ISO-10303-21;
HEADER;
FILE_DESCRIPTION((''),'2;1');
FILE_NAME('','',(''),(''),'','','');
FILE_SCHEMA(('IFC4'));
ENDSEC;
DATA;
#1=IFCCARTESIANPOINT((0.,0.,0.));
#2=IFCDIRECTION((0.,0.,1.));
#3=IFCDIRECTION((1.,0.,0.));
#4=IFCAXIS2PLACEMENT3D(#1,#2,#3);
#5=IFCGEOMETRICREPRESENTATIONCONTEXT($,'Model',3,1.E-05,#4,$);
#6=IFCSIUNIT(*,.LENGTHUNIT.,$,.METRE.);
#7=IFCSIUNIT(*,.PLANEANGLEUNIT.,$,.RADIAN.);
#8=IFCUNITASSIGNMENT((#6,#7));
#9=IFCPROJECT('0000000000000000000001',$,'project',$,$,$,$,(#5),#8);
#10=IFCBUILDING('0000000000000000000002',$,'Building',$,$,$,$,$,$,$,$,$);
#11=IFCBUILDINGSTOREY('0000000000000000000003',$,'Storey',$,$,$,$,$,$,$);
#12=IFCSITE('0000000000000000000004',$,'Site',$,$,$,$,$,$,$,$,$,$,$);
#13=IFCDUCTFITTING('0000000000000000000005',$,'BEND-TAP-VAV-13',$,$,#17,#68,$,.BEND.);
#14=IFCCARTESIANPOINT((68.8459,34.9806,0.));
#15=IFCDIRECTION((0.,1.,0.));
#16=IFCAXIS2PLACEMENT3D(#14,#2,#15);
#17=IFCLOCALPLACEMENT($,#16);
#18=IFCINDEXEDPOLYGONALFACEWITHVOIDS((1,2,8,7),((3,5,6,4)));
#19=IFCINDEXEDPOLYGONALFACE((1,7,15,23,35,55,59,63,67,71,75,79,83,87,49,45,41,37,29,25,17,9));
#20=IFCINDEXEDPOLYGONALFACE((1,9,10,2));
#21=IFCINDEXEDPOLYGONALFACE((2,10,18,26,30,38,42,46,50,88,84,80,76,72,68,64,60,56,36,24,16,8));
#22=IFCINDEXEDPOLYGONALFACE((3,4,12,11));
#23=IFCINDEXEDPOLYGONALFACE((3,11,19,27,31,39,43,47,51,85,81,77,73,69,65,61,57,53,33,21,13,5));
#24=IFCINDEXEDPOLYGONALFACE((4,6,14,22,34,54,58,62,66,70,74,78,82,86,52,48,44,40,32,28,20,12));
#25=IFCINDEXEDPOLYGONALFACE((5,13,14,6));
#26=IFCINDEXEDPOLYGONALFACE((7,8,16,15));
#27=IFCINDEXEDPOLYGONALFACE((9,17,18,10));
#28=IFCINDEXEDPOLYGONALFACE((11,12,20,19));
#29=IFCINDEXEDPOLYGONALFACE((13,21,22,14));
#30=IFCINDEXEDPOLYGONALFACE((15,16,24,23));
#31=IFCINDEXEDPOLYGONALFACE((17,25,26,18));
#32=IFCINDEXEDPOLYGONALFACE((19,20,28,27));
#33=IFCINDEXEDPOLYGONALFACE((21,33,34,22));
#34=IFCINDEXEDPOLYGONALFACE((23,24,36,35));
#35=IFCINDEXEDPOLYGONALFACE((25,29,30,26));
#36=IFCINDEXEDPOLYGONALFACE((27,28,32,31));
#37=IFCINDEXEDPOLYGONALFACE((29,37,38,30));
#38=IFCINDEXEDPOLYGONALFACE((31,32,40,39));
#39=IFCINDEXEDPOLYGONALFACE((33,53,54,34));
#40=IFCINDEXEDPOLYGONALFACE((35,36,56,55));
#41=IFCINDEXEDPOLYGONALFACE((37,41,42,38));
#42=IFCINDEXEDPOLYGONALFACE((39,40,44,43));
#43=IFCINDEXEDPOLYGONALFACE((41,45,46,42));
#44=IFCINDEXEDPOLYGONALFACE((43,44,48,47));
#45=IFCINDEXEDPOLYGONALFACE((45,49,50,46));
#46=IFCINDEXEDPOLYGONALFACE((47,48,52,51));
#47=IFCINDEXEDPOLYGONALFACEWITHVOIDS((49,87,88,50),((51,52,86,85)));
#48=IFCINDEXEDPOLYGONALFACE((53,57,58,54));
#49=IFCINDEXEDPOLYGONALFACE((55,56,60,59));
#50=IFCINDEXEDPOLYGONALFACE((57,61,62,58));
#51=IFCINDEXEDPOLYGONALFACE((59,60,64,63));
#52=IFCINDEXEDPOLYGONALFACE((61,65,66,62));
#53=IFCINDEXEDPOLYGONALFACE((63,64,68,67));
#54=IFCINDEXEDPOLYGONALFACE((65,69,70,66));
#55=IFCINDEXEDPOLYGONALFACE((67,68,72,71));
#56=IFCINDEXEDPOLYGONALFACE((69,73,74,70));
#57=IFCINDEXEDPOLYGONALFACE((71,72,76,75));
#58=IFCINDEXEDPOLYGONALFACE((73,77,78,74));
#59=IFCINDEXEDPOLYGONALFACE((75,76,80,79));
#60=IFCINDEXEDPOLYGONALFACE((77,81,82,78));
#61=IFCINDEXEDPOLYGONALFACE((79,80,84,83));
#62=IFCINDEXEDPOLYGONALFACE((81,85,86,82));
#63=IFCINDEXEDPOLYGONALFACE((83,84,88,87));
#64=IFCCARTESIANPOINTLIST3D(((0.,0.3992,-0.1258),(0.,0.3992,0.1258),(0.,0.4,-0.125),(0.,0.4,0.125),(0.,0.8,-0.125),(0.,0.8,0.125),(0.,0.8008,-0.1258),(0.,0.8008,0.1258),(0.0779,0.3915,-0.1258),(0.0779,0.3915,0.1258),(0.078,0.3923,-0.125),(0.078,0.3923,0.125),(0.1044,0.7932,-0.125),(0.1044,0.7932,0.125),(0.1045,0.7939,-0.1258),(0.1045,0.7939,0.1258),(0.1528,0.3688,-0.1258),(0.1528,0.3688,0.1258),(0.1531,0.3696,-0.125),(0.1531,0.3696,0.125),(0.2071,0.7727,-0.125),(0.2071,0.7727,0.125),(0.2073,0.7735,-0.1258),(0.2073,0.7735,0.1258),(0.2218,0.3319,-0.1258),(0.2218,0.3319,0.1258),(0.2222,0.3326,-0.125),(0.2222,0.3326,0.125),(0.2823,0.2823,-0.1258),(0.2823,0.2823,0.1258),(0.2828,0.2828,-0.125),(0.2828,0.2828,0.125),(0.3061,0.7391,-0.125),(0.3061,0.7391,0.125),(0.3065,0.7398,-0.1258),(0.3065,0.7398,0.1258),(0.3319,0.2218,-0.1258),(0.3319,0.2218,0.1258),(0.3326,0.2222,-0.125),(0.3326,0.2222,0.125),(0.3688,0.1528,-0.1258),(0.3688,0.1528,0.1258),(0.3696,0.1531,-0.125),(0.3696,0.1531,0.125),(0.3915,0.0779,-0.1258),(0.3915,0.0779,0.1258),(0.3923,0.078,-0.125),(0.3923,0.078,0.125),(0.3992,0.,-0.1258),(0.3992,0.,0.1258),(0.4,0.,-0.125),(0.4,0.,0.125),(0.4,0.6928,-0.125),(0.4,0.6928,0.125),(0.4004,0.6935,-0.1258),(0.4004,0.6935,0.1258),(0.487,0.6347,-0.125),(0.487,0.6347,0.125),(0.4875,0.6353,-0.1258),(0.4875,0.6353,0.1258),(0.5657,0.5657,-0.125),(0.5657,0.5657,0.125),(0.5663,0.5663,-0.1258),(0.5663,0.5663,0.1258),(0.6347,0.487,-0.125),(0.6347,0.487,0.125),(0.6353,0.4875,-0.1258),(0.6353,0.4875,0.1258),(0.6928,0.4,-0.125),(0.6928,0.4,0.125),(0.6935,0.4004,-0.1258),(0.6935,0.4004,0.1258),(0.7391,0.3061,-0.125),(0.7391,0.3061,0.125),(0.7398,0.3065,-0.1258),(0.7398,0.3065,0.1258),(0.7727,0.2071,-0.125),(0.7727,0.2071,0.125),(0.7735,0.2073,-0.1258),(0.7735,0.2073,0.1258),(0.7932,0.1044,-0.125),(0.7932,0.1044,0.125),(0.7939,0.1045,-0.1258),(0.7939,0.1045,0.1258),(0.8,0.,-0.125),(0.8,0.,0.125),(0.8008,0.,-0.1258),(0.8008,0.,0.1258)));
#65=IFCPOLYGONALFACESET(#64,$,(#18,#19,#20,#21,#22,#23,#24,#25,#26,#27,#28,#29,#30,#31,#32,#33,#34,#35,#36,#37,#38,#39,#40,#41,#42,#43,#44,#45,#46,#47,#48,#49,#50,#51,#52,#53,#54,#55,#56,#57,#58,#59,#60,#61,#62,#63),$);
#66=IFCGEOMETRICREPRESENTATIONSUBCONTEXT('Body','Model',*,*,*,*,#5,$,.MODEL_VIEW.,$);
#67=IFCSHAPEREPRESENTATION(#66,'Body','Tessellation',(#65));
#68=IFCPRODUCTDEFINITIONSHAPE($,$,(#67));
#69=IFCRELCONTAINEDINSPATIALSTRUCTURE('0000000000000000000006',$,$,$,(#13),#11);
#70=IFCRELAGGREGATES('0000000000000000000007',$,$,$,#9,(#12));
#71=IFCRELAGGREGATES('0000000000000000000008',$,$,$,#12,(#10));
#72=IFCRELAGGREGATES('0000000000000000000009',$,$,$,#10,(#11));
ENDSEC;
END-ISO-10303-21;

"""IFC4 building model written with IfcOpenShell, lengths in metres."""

from ifc_helpers import new_model, entity, si_unit, frame, origin_with_axes, place, context, subcontext, project, spatial, element, save


model = new_model("IFC4")

# Units and contexts
model_context = context("Model", 3, precision=1e-05, world=origin_with_axes())
body_context = subcontext(model_context, "Body", "Model", "MODEL_VIEW")
ifc_project = project(units=[si_unit("LENGTHUNIT", "METRE"), si_unit("PLANEANGLEUNIT", "RADIAN")], contexts=[model_context])

# Site, building, storey
site = spatial("IfcSite", under=ifc_project, Name="Site")
building = spatial("IfcBuilding", under=site, Name="Building")
storey = spatial("IfcBuildingStorey", under=building, Name="Storey")

# Duct fitting
duct_fitting_1_placement = place(None, frame((68.8459, 34.9806, 0.0), z_axis=(0.0, 0.0, 1.0), x_axis=(0.0, 1.0, 0.0)))
cartesian_point_1 = entity("IfcCartesianPoint", [0.0, 0.0, 0.0])
element("IfcDuctFitting", 1, at=duct_fitting_1_placement, inside=storey, Name="BEND-TAP-VAV-13", PredefinedType="BEND", context=body_context, shape_type="SweptSolid", body=[
    entity("IfcRevolvedAreaSolid", entity("IfcRectangleHollowProfileDef", "AREA", None, entity("IfcAxis2Placement2D", entity("IfcCartesianPoint", [0.6, 0.0])), 0.4016, 0.2516, 0.0008), entity("IfcAxis2Placement3D", cartesian_point_1, entity("IfcDirection", [0.0, -1.0, 0.0]), entity("IfcDirection", [1.0, 0.0, 0.0])), entity("IfcAxis1Placement", cartesian_point_1, entity("IfcDirection", [0.0, 1.0, 0.0])), 1.570796),
])

save(model, "model.ifc")
